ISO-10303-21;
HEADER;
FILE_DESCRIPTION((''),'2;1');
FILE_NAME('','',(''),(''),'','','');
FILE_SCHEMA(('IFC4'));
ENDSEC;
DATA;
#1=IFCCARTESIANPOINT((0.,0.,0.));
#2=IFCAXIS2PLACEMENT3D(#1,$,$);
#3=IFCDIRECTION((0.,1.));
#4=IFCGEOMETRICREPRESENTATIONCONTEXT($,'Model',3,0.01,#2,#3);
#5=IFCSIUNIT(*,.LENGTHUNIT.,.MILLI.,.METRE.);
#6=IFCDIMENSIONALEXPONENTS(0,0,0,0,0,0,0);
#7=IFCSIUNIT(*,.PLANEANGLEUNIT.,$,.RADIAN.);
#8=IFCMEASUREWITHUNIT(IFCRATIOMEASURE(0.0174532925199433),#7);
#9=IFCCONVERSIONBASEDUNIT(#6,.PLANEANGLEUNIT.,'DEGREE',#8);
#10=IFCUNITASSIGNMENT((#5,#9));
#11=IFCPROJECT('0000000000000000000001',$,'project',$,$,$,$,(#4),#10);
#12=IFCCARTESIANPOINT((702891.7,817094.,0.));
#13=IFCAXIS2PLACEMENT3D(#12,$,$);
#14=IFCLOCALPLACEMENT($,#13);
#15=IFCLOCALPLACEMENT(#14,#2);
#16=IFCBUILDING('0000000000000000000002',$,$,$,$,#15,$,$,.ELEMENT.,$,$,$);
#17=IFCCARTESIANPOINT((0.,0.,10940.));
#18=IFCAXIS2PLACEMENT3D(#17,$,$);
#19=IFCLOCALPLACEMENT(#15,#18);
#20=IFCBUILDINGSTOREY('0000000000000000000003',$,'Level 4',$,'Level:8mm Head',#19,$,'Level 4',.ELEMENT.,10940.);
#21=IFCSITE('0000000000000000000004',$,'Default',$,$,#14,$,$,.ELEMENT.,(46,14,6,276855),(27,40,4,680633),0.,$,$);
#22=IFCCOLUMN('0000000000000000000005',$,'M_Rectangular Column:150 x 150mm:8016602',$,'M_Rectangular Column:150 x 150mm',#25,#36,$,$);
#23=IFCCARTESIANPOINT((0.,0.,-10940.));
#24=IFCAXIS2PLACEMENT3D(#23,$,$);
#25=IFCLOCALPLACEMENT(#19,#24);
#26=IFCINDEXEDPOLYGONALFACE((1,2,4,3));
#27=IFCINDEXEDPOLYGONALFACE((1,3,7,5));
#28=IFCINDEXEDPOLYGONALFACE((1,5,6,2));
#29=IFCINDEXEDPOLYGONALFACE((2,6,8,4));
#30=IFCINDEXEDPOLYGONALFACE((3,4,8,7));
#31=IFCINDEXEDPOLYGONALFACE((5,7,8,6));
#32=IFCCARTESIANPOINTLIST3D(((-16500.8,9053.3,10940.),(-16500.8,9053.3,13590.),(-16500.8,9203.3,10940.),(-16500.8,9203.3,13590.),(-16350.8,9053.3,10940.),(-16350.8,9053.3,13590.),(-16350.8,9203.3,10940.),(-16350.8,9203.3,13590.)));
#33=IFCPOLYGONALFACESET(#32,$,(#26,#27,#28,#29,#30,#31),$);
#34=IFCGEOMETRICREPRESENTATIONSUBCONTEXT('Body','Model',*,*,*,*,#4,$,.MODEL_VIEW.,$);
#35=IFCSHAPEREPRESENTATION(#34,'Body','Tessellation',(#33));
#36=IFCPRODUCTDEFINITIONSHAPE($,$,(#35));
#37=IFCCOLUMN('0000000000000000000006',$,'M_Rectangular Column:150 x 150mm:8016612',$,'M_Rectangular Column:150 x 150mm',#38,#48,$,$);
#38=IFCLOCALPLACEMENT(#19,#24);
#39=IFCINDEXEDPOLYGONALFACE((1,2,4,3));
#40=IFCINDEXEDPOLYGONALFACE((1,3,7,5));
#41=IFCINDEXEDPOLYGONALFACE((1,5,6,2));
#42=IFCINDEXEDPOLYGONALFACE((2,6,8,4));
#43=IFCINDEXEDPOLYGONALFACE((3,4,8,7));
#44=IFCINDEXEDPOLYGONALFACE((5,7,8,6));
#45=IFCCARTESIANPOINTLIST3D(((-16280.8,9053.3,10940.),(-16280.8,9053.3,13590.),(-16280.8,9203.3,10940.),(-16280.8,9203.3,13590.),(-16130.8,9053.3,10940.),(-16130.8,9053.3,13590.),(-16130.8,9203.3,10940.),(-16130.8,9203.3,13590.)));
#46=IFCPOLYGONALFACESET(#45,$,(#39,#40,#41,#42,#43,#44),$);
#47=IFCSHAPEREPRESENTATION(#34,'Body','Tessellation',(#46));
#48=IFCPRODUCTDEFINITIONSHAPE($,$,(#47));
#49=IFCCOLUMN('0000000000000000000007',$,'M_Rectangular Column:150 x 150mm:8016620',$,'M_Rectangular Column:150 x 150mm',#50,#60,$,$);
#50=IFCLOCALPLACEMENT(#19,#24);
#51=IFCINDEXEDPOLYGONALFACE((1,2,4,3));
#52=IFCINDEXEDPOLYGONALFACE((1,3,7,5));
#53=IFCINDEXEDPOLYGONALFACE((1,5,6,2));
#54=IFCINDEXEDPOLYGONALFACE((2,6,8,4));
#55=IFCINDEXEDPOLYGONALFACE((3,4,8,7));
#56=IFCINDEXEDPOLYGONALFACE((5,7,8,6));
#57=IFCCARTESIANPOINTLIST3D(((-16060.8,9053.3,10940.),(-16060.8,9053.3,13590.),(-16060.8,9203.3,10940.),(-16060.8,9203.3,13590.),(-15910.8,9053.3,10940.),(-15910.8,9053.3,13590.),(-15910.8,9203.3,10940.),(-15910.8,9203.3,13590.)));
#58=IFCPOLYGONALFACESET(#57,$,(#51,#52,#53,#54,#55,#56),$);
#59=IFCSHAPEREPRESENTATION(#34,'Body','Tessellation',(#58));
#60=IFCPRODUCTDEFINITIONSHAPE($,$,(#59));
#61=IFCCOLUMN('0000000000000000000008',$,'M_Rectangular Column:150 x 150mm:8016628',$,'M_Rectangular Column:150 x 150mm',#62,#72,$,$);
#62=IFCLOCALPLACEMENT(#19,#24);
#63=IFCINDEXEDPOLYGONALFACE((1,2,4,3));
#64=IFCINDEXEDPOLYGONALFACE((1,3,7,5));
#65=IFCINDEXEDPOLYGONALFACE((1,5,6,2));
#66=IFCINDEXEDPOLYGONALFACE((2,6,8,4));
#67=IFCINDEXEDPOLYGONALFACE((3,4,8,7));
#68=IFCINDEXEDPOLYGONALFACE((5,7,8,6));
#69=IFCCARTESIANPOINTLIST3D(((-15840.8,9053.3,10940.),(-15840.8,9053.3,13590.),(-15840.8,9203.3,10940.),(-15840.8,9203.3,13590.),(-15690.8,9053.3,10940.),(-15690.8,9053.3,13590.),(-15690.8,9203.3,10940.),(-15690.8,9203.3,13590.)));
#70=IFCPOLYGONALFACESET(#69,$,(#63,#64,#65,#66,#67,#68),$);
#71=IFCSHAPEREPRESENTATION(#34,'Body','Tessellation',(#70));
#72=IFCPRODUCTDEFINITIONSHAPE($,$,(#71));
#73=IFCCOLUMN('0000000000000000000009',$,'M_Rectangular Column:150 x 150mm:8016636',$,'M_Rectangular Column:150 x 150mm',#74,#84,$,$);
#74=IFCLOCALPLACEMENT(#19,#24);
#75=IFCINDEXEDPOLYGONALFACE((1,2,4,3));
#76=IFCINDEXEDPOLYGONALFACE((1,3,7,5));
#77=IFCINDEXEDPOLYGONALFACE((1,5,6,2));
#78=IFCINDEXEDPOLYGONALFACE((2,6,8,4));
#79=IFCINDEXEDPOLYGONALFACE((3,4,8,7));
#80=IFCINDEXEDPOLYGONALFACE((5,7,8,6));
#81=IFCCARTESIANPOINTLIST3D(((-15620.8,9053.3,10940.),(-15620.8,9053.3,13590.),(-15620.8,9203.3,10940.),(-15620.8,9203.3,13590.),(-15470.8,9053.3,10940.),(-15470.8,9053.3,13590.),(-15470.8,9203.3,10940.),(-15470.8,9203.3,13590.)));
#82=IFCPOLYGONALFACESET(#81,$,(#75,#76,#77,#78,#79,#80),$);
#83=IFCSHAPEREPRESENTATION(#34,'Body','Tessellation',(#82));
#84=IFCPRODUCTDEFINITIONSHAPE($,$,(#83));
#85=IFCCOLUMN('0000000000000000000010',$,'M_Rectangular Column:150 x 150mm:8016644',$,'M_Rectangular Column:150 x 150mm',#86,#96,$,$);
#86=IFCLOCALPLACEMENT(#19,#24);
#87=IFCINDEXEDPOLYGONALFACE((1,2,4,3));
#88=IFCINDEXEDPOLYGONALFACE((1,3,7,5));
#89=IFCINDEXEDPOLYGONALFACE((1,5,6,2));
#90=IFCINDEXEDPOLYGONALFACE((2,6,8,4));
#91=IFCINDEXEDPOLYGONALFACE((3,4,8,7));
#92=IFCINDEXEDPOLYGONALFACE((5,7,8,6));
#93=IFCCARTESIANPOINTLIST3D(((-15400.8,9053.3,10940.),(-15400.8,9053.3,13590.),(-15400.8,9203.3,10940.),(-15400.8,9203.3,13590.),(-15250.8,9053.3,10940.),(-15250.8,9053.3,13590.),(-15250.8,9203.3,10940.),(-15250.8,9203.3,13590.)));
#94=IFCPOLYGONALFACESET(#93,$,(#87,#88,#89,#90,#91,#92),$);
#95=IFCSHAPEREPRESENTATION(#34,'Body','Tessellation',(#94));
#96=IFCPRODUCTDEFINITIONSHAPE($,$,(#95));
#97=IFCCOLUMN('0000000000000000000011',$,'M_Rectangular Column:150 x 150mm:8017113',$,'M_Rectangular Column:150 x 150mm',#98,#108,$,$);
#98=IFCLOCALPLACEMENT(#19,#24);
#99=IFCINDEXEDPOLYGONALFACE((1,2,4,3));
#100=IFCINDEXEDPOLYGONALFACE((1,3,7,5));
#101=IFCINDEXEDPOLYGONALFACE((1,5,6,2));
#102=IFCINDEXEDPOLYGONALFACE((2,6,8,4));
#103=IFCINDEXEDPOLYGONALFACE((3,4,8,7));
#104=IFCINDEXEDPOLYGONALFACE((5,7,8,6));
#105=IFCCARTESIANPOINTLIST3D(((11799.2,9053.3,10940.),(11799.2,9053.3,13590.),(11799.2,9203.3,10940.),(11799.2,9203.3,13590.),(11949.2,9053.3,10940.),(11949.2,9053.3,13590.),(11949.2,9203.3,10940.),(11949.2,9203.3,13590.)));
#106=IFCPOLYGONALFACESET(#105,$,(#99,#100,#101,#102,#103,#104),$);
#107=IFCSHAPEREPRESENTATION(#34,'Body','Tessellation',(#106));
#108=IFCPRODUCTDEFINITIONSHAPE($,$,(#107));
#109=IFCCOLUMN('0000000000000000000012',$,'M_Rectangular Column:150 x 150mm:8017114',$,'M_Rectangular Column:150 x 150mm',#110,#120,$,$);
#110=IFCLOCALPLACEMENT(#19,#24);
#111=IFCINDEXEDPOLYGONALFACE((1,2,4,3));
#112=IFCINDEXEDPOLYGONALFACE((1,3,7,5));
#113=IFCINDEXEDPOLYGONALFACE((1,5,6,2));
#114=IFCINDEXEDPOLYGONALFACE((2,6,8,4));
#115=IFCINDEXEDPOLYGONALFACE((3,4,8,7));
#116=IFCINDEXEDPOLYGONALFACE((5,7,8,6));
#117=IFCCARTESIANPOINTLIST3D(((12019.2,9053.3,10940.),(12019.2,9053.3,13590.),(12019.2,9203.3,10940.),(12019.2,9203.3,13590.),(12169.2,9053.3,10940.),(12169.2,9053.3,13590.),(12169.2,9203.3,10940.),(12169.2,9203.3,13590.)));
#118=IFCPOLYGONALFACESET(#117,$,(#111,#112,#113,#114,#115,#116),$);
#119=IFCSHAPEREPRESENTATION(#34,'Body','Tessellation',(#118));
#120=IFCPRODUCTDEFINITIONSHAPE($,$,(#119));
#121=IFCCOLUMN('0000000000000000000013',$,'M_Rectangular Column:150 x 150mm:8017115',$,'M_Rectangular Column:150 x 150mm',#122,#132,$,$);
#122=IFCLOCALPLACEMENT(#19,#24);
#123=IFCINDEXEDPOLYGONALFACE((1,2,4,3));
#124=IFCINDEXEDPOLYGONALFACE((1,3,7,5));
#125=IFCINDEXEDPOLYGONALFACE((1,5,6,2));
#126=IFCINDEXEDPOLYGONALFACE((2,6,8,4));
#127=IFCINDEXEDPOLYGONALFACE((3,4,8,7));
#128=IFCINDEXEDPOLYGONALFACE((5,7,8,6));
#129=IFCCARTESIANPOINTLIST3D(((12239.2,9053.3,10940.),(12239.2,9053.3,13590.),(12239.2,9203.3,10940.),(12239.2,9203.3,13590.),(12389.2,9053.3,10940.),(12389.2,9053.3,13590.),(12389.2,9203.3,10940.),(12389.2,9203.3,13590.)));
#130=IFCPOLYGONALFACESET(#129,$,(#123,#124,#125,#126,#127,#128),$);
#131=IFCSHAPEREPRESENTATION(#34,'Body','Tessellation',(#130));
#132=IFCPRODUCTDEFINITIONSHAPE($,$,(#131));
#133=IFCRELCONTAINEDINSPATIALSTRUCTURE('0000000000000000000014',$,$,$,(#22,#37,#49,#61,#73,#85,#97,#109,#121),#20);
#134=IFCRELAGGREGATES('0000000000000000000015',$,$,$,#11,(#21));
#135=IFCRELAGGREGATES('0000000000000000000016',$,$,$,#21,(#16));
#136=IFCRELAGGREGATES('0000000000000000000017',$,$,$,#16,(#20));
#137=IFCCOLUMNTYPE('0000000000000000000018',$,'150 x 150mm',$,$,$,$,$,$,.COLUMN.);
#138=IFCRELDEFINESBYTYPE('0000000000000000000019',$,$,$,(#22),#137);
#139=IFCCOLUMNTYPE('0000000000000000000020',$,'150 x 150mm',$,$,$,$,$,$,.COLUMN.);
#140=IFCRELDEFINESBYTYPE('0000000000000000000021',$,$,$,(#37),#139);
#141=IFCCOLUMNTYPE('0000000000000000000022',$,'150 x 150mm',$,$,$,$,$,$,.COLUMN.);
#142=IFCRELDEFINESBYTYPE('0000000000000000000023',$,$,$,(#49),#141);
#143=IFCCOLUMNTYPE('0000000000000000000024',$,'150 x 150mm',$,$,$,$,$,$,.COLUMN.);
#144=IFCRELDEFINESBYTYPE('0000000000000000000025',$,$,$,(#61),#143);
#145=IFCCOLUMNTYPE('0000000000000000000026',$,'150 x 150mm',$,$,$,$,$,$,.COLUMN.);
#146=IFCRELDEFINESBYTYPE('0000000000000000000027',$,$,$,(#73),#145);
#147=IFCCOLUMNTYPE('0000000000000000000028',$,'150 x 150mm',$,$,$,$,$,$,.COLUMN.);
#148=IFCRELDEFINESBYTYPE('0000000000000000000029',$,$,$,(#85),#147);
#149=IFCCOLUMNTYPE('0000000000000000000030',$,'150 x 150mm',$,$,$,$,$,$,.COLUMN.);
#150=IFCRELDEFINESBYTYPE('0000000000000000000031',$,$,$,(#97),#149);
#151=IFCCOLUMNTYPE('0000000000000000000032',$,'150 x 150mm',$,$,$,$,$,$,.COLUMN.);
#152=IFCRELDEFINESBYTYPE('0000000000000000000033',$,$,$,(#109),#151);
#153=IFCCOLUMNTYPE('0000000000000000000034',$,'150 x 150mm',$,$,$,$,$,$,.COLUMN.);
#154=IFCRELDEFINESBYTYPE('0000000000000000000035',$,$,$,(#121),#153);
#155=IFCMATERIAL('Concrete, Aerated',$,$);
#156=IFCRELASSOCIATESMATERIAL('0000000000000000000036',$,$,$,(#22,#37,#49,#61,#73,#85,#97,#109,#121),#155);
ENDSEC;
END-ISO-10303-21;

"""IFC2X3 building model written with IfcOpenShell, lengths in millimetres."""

from ifc_helpers import new_model, entity, si_unit, converted_unit, direction, frame, frame_2d, origin, place, context, subcontext, project, spatial, rectangle, extrude, source, transform, mapped, material, type_object, type_shapes, element, save


model = new_model("IFC2X3")

# Units and contexts
model_context = context("Model", 3, precision=0.01, world=origin(), true_north=direction((0.0, 1.0)))
body_context = subcontext(model_context, "Body", "Model", "MODEL_VIEW")
ifc_project = project(units=[si_unit("LENGTHUNIT", "METRE", prefix="MILLI"), converted_unit("PLANEANGLEUNIT", "DEGREE", entity("IfcRatioMeasure", 0.0174532925199433), si_unit("PLANEANGLEUNIT", "RADIAN"), dimensions=[0, 0, 0, 0, 0, 0, 0])], contexts=[model_context])

# Site, building, storey
site_placement = place(None, frame((702891.7, 817094.0, 0.0)))
site = spatial("IfcSite", under=ifc_project, at=site_placement, Name="Default", CompositionType="ELEMENT", RefLatitude=(46, 14, 6, 276855), RefLongitude=(27, 40, 4, 680633), RefElevation=0.0)
building_placement = place(site_placement, origin())
building = spatial("IfcBuilding", under=site, at=building_placement, CompositionType="ELEMENT")
storey_placement = place(building_placement, frame((0.0, 0.0, 10940.0)))
storey = spatial("IfcBuildingStorey", under=building, at=storey_placement, Name="Level 4", ObjectType="Level:8mm Head", LongName="Level 4", CompositionType="ELEMENT", Elevation=10940.0)

# Columns
ifc_material_1 = material(Name="Concrete, Aerated")
column_type_1 = type_object("IfcColumnType", Name="150 x 150mm", PredefinedType="COLUMN")
shared_shape_1 = source(origin(), body_context, "Body", "SweptSolid", [
    extrude(rectangle(XDim=150.0, YDim=150.0, at=frame_2d((0.0, 0.0), x_axis=(1.0, 0.0))), frame((-16425.8, 9128.3, 10940.0), z_axis=(0.0, 0.0, 1.0), x_axis=(0.0, -1.0, 0.0)), (0.0, 0.0, 1.0), 2650.0),
])
type_shapes(column_type_1, [shared_shape_1])
column_1_placement = place(storey_placement, frame((0.0, 0.0, -10940.0)))
element("IfcColumn", 1, at=column_1_placement, inside=storey, type_object=column_type_1, material=ifc_material_1, Name="M_Rectangular Column:150 x 150mm:8016602", ObjectType="M_Rectangular Column:150 x 150mm", context=body_context, shape_type="MappedRepresentation", body=[
    mapped(shared_shape_1, transform((0.0, 0.0, 0.0), scale=1.0)),
])
column_type_2 = type_object("IfcColumnType", Name="150 x 150mm", PredefinedType="COLUMN")
shared_shape_2 = source(origin(), body_context, "Body", "SweptSolid", [
    extrude(rectangle(XDim=150.0, YDim=150.0, at=frame_2d((0.0, 0.0), x_axis=(1.0, 0.0))), frame((-16205.8, 9128.3, 10940.0), z_axis=(0.0, 0.0, 1.0), x_axis=(0.0, -1.0, 0.0)), (0.0, 0.0, 1.0), 2650.0),
])
type_shapes(column_type_2, [shared_shape_2])
column_2_placement = place(storey_placement, frame((0.0, 0.0, -10940.0)))
element("IfcColumn", 2, at=column_2_placement, inside=storey, type_object=column_type_2, material=ifc_material_1, Name="M_Rectangular Column:150 x 150mm:8016612", ObjectType="M_Rectangular Column:150 x 150mm", context=body_context, shape_type="MappedRepresentation", body=[
    mapped(shared_shape_2, transform((0.0, 0.0, 0.0), scale=1.0)),
])
column_type_3 = type_object("IfcColumnType", Name="150 x 150mm", PredefinedType="COLUMN")
shared_shape_3 = source(origin(), body_context, "Body", "SweptSolid", [
    extrude(rectangle(XDim=150.0, YDim=150.0, at=frame_2d((0.0, 0.0), x_axis=(1.0, 0.0))), frame((-15985.8, 9128.3, 10940.0), z_axis=(0.0, 0.0, 1.0), x_axis=(0.0, -1.0, 0.0)), (0.0, 0.0, 1.0), 2650.0),
])
type_shapes(column_type_3, [shared_shape_3])
column_3_placement = place(storey_placement, frame((0.0, 0.0, -10940.0)))
element("IfcColumn", 3, at=column_3_placement, inside=storey, type_object=column_type_3, material=ifc_material_1, Name="M_Rectangular Column:150 x 150mm:8016620", ObjectType="M_Rectangular Column:150 x 150mm", context=body_context, shape_type="MappedRepresentation", body=[
    mapped(shared_shape_3, transform((0.0, 0.0, 0.0), scale=1.0)),
])
column_type_4 = type_object("IfcColumnType", Name="150 x 150mm", PredefinedType="COLUMN")
shared_shape_4 = source(origin(), body_context, "Body", "SweptSolid", [
    extrude(rectangle(XDim=150.0, YDim=150.0, at=frame_2d((0.0, 0.0), x_axis=(1.0, 0.0))), frame((-15765.8, 9128.3, 10940.0), z_axis=(0.0, 0.0, 1.0), x_axis=(0.0, -1.0, 0.0)), (0.0, 0.0, 1.0), 2650.0),
])
type_shapes(column_type_4, [shared_shape_4])
column_4_placement = place(storey_placement, frame((0.0, 0.0, -10940.0)))
element("IfcColumn", 4, at=column_4_placement, inside=storey, type_object=column_type_4, material=ifc_material_1, Name="M_Rectangular Column:150 x 150mm:8016628", ObjectType="M_Rectangular Column:150 x 150mm", context=body_context, shape_type="MappedRepresentation", body=[
    mapped(shared_shape_4, transform((0.0, 0.0, 0.0), scale=1.0)),
])
column_type_5 = type_object("IfcColumnType", Name="150 x 150mm", PredefinedType="COLUMN")
shared_shape_5 = source(origin(), body_context, "Body", "SweptSolid", [
    extrude(rectangle(XDim=150.0, YDim=150.0, at=frame_2d((0.0, 0.0), x_axis=(1.0, 0.0))), frame((-15545.8, 9128.3, 10940.0), z_axis=(0.0, 0.0, 1.0), x_axis=(0.0, -1.0, 0.0)), (0.0, 0.0, 1.0), 2650.0),
])
type_shapes(column_type_5, [shared_shape_5])
column_5_placement = place(storey_placement, frame((0.0, 0.0, -10940.0)))
element("IfcColumn", 5, at=column_5_placement, inside=storey, type_object=column_type_5, material=ifc_material_1, Name="M_Rectangular Column:150 x 150mm:8016636", ObjectType="M_Rectangular Column:150 x 150mm", context=body_context, shape_type="MappedRepresentation", body=[
    mapped(shared_shape_5, transform((0.0, 0.0, 0.0), scale=1.0)),
])
column_type_6 = type_object("IfcColumnType", Name="150 x 150mm", PredefinedType="COLUMN")
shared_shape_6 = source(origin(), body_context, "Body", "SweptSolid", [
    extrude(rectangle(XDim=150.0, YDim=150.0, at=frame_2d((0.0, 0.0), x_axis=(1.0, 0.0))), frame((-15325.8, 9128.3, 10940.0), z_axis=(0.0, 0.0, 1.0), x_axis=(0.0, -1.0, 0.0)), (0.0, 0.0, 1.0), 2650.0),
])
type_shapes(column_type_6, [shared_shape_6])
column_6_placement = place(storey_placement, frame((0.0, 0.0, -10940.0)))
element("IfcColumn", 6, at=column_6_placement, inside=storey, type_object=column_type_6, material=ifc_material_1, Name="M_Rectangular Column:150 x 150mm:8016644", ObjectType="M_Rectangular Column:150 x 150mm", context=body_context, shape_type="MappedRepresentation", body=[
    mapped(shared_shape_6, transform((0.0, 0.0, 0.0), scale=1.0)),
])
column_type_7 = type_object("IfcColumnType", Name="150 x 150mm", PredefinedType="COLUMN")
shared_shape_7 = source(origin(), body_context, "Body", "SweptSolid", [
    extrude(rectangle(XDim=150.0, YDim=150.0, at=frame_2d((0.0, 0.0), x_axis=(1.0, 0.0))), frame((11874.2, 9128.3, 10940.0), z_axis=(0.0, 0.0, 1.0), x_axis=(0.0, -1.0, 0.0)), (0.0, 0.0, 1.0), 2650.0),
])
type_shapes(column_type_7, [shared_shape_7])
column_7_placement = place(storey_placement, frame((0.0, 0.0, -10940.0)))
element("IfcColumn", 7, at=column_7_placement, inside=storey, type_object=column_type_7, material=ifc_material_1, Name="M_Rectangular Column:150 x 150mm:8017113", ObjectType="M_Rectangular Column:150 x 150mm", context=body_context, shape_type="MappedRepresentation", body=[
    mapped(shared_shape_7, transform((0.0, 0.0, 0.0), scale=1.0)),
])
column_type_8 = type_object("IfcColumnType", Name="150 x 150mm", PredefinedType="COLUMN")
shared_shape_8 = source(origin(), body_context, "Body", "SweptSolid", [
    extrude(rectangle(XDim=150.0, YDim=150.0, at=frame_2d((0.0, 0.0), x_axis=(1.0, 0.0))), frame((12094.2, 9128.3, 10940.0), z_axis=(0.0, 0.0, 1.0), x_axis=(0.0, -1.0, 0.0)), (0.0, 0.0, 1.0), 2650.0),
])
type_shapes(column_type_8, [shared_shape_8])
column_8_placement = place(storey_placement, frame((0.0, 0.0, -10940.0)))
element("IfcColumn", 8, at=column_8_placement, inside=storey, type_object=column_type_8, material=ifc_material_1, Name="M_Rectangular Column:150 x 150mm:8017114", ObjectType="M_Rectangular Column:150 x 150mm", context=body_context, shape_type="MappedRepresentation", body=[
    mapped(shared_shape_8, transform((0.0, 0.0, 0.0), scale=1.0)),
])
column_type_9 = type_object("IfcColumnType", Name="150 x 150mm", PredefinedType="COLUMN")
shared_shape_9 = source(origin(), body_context, "Body", "SweptSolid", [
    extrude(rectangle(XDim=150.0, YDim=150.0, at=frame_2d((0.0, 0.0), x_axis=(1.0, 0.0))), frame((12314.2, 9128.3, 10940.0), z_axis=(0.0, 0.0, 1.0), x_axis=(0.0, -1.0, 0.0)), (0.0, 0.0, 1.0), 2650.0),
])
type_shapes(column_type_9, [shared_shape_9])
column_9_placement = place(storey_placement, frame((0.0, 0.0, -10940.0)))
element("IfcColumn", 9, at=column_9_placement, inside=storey, type_object=column_type_9, material=ifc_material_1, Name="M_Rectangular Column:150 x 150mm:8017115", ObjectType="M_Rectangular Column:150 x 150mm", context=body_context, shape_type="MappedRepresentation", body=[
    mapped(shared_shape_9, transform((0.0, 0.0, 0.0), scale=1.0)),
])

save(model, "model.ifc")
